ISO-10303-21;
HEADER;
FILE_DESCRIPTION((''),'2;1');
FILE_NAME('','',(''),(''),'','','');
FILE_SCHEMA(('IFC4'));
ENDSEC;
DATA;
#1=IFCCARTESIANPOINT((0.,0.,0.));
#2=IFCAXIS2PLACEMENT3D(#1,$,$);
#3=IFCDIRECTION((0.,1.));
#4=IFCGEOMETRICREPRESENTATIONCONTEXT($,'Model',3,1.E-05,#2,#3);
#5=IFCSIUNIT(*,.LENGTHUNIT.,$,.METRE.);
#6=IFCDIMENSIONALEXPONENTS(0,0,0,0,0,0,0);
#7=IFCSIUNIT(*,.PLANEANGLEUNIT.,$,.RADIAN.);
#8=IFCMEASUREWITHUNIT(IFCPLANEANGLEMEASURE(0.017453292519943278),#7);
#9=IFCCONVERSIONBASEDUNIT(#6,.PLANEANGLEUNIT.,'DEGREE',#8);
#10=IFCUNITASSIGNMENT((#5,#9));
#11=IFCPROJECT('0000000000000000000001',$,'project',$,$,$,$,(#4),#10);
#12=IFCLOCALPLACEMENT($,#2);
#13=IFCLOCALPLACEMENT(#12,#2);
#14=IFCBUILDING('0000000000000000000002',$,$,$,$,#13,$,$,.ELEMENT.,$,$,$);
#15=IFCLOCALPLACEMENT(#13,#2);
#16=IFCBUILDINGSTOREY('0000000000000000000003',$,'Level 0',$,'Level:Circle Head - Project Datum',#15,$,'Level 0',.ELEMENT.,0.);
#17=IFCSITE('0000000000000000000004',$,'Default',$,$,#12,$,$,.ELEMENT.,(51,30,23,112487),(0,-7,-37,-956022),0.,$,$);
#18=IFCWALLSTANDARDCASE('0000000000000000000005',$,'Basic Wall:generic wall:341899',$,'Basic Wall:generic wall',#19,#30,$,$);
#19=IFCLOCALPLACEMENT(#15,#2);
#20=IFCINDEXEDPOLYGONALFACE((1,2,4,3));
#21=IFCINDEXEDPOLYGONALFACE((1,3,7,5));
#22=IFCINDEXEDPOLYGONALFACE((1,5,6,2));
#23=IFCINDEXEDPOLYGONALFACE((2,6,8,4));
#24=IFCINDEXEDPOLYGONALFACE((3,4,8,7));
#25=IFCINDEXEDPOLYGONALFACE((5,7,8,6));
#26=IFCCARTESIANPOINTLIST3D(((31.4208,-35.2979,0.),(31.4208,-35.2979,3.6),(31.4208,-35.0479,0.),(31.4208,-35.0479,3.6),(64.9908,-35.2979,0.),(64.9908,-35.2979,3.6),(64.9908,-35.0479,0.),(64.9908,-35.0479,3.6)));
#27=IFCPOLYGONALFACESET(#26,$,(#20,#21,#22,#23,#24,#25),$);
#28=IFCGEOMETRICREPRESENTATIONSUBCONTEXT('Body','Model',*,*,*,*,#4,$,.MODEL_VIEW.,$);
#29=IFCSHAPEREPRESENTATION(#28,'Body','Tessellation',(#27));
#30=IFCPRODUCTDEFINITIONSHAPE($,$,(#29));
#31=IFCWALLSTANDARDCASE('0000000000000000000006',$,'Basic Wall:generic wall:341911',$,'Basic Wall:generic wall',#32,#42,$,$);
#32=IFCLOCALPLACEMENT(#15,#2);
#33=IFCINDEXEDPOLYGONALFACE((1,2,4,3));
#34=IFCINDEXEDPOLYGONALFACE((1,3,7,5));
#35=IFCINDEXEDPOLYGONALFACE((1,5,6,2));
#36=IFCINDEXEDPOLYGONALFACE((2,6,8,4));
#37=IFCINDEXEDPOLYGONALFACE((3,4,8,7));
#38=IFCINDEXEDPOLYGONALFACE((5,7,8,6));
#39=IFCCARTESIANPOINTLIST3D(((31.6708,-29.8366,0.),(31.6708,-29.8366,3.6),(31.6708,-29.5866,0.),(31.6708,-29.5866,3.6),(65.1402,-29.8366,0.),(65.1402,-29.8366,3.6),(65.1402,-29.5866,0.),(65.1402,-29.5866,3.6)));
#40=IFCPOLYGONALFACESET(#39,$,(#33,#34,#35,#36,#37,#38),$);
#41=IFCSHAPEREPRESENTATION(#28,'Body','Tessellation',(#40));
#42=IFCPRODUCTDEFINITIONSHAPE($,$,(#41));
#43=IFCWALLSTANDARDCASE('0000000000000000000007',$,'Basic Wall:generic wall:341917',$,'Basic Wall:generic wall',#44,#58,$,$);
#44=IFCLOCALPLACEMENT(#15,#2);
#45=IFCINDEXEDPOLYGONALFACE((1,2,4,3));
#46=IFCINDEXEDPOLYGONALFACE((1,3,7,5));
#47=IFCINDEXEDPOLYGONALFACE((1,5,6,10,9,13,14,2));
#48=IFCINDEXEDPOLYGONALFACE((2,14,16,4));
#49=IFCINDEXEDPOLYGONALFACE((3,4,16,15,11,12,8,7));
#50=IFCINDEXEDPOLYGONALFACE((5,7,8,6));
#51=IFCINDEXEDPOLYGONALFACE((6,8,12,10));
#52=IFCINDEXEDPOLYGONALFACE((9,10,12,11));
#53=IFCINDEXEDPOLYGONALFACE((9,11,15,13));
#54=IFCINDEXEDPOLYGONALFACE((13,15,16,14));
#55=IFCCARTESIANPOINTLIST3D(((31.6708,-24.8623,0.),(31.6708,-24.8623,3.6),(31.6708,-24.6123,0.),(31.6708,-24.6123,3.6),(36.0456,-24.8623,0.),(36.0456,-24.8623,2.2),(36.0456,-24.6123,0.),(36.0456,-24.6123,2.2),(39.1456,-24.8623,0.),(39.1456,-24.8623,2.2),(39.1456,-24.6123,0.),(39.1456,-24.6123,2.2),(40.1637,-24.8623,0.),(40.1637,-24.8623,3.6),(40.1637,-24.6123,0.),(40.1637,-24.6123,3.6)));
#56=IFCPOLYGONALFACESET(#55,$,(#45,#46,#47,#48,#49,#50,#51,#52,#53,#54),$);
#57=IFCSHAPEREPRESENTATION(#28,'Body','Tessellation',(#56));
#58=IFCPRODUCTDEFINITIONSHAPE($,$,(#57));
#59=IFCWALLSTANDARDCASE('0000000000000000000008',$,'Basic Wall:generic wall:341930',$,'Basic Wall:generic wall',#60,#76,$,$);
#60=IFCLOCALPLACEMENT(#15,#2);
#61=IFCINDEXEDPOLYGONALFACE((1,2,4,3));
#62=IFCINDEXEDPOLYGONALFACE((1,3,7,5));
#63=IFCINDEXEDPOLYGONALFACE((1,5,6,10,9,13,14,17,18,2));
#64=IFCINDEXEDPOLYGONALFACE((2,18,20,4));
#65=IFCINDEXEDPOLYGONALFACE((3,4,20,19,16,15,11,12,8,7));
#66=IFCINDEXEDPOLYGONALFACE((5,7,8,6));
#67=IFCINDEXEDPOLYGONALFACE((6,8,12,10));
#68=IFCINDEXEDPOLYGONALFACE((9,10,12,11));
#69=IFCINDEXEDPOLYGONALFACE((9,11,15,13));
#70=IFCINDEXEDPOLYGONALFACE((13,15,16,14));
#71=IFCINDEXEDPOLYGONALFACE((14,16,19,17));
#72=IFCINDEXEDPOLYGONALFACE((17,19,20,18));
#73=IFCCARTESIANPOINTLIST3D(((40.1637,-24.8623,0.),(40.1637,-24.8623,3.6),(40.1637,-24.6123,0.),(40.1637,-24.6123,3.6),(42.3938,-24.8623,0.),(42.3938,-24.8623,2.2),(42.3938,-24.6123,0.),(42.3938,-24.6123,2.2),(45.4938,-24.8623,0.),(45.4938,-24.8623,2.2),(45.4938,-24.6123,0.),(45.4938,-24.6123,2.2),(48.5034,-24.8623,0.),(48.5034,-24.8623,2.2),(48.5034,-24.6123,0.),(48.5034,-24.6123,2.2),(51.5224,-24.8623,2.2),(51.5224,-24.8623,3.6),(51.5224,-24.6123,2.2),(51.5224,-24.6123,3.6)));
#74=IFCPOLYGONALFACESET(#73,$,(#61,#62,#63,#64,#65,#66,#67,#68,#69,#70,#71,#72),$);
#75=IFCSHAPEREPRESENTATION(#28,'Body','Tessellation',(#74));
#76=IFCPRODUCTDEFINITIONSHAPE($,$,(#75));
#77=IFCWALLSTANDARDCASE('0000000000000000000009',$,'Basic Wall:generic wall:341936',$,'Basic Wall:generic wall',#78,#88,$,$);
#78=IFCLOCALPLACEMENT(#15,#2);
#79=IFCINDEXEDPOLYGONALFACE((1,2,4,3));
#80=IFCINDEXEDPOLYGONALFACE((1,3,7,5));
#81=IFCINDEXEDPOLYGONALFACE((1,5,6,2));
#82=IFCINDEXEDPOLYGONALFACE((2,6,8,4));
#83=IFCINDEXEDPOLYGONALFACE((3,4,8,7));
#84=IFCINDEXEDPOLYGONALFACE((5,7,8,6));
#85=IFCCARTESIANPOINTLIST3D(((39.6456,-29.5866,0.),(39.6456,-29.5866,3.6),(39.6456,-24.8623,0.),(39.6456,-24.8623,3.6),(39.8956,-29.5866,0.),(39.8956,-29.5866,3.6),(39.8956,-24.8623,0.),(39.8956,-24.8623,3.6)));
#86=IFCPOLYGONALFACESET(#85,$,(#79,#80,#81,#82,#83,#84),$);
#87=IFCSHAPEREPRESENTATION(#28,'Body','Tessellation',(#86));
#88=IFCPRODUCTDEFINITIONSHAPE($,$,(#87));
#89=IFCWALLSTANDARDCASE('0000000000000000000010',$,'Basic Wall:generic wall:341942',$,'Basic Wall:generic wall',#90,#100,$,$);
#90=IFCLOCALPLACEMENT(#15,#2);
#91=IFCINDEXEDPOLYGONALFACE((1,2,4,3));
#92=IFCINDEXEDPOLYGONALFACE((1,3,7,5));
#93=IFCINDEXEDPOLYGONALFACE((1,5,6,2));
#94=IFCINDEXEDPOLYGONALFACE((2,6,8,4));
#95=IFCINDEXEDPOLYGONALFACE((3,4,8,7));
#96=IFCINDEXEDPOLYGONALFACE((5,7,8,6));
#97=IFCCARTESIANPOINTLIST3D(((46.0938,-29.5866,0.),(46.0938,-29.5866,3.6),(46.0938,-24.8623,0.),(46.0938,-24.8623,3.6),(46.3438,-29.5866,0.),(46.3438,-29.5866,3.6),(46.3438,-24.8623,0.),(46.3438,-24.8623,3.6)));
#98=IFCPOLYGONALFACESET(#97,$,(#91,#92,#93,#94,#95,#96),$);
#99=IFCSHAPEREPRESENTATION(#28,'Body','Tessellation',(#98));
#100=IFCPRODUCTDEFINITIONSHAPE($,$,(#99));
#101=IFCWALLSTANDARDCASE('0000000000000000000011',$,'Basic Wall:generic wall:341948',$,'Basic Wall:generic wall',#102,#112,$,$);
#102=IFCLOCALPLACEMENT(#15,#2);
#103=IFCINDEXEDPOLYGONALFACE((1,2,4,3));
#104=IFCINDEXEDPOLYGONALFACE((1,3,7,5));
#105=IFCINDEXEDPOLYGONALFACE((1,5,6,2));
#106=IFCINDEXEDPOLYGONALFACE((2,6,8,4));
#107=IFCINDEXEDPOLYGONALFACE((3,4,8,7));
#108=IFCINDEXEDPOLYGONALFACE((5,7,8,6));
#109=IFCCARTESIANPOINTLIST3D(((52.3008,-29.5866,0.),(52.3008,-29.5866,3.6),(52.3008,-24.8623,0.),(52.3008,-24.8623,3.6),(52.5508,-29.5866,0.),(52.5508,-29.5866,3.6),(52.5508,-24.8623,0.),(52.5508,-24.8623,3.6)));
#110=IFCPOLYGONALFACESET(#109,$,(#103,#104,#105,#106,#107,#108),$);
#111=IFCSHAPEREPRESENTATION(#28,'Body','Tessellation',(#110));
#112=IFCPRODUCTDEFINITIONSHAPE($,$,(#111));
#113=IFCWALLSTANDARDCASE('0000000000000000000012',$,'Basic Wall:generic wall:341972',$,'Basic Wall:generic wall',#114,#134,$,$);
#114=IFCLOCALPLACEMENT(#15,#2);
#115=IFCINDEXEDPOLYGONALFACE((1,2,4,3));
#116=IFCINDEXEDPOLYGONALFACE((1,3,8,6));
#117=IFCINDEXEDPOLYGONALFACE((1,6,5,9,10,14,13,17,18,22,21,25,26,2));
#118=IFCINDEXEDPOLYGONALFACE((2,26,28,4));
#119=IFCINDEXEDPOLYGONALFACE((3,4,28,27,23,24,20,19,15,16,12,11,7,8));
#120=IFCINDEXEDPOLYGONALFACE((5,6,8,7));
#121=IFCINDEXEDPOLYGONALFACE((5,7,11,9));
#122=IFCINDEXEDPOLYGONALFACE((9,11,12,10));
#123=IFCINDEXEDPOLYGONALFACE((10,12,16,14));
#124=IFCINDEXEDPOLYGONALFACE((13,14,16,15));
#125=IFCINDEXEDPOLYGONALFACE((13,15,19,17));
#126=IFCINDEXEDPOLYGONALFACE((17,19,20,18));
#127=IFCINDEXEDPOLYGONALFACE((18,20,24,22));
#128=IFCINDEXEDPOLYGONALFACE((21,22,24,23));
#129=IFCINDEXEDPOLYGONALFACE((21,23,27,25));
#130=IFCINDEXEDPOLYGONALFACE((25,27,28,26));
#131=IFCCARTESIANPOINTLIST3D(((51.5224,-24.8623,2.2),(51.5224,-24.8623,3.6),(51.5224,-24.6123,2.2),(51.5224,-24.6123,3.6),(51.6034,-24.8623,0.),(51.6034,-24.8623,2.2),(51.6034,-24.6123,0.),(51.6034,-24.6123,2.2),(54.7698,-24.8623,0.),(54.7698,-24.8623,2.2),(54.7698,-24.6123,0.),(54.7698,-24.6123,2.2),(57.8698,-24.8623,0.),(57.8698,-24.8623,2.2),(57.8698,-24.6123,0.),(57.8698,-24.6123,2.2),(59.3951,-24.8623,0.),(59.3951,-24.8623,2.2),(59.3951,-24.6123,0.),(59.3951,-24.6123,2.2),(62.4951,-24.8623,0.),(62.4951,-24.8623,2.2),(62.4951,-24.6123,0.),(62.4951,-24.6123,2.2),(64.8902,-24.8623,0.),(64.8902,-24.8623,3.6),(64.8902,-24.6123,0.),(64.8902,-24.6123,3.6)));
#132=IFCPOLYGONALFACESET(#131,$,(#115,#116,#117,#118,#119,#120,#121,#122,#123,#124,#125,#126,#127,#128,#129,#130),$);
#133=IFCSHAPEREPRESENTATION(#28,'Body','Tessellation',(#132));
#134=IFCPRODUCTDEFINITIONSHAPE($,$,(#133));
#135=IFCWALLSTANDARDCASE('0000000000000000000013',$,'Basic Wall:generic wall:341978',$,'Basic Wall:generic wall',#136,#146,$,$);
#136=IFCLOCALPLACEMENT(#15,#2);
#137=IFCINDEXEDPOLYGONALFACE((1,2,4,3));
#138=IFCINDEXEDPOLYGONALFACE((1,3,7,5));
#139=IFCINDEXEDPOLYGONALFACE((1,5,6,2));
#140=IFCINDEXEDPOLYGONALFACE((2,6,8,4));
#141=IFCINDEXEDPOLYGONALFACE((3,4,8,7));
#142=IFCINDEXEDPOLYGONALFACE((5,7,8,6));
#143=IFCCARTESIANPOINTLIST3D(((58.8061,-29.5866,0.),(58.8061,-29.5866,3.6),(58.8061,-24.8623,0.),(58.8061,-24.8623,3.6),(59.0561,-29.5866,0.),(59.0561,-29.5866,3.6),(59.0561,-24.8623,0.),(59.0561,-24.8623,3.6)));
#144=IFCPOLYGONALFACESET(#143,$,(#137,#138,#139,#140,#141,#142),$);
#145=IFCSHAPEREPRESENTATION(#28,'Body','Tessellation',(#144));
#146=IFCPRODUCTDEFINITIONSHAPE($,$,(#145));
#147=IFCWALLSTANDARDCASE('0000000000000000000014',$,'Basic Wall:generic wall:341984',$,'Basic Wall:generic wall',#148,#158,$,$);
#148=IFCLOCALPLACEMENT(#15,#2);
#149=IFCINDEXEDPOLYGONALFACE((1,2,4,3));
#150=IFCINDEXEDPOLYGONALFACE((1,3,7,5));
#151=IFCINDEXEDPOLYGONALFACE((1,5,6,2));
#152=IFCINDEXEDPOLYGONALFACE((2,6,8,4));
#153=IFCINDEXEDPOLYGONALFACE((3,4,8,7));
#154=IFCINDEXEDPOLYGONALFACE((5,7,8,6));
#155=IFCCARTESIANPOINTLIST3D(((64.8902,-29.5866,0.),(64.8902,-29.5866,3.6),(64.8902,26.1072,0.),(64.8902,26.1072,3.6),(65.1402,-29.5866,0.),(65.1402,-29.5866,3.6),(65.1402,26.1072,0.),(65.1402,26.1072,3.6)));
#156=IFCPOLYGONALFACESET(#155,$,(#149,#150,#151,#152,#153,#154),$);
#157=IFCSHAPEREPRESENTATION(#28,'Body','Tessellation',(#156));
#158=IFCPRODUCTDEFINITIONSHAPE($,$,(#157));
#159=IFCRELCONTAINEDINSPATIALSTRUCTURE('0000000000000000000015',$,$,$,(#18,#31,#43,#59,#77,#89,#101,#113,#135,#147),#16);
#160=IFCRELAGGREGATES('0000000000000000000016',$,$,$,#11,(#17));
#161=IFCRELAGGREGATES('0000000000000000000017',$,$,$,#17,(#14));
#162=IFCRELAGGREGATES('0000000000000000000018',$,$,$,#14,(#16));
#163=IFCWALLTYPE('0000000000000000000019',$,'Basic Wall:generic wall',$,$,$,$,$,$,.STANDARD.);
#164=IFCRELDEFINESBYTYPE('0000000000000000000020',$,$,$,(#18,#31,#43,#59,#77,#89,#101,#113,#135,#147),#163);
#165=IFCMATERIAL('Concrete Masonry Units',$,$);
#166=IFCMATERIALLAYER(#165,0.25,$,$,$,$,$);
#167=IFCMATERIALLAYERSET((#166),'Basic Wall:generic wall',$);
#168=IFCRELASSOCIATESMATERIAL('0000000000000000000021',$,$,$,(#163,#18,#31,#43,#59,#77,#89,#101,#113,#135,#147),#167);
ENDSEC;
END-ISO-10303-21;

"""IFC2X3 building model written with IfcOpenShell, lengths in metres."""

from ifc_helpers import new_model, entity, si_unit, converted_unit, direction, frame, frame_2d, origin, place, context, subcontext, project, spatial, rectangle, extrude, material, layer, layer_set, layer_usage, type_object, element, save


model = new_model("IFC2X3")

# Units and contexts
model_context = context("Model", 3, precision=1e-05, world=origin(), true_north=direction((0.0, 1.0)))
body_context = subcontext(model_context, "Body", "Model", "MODEL_VIEW")
ifc_project = project(units=[si_unit("LENGTHUNIT", "METRE"), converted_unit("PLANEANGLEUNIT", "DEGREE", entity("IfcPlaneAngleMeasure", 0.017453292519943278), si_unit("PLANEANGLEUNIT", "RADIAN"), dimensions=[0, 0, 0, 0, 0, 0, 0])], contexts=[model_context])

# Site, building, storey
site_placement = place(None, origin())
site = spatial("IfcSite", under=ifc_project, at=site_placement, Name="Default", CompositionType="ELEMENT", RefLatitude=(51, 30, 23, 112487), RefLongitude=(0, -7, -37, -956022), RefElevation=0.0)
building_placement = place(site_placement, origin())
building = spatial("IfcBuilding", under=site, at=building_placement, CompositionType="ELEMENT")
storey_placement = place(building_placement, origin())
storey = spatial("IfcBuildingStorey", under=building, at=storey_placement, Name="Level 0", ObjectType="Level:Circle Head - Project Datum", LongName="Level 0", CompositionType="ELEMENT", Elevation=0.0)

# Shared definitions
ifc_material = material(Name="Concrete Masonry Units")
ifc_layer = layer(ifc_material, 0.25)
ifc_layer_set = layer_set([ifc_layer], Name="Basic Wall:generic wall")
wall_type = type_object("IfcWallType", Name="Basic Wall:generic wall", PredefinedType="STANDARD", material=ifc_layer_set)

# Walls
ifc_layer_usage_1 = layer_usage(ifc_layer_set, "AXIS2", "NEGATIVE", 0.125)
wall_1_placement = place(storey_placement, frame((64.9908, -35.1729, 0.0), z_axis=(0.0, 0.0, 1.0), x_axis=(-1.0, 0.0, 0.0)))
element("IfcWallStandardCase", 1, at=wall_1_placement, inside=storey, type_object=wall_type, material=ifc_layer_usage_1, Name="Basic Wall:generic wall:341899", ObjectType="Basic Wall:generic wall", context=body_context, shape_type="SweptSolid", body=[
    extrude(rectangle(XDim=33.57, YDim=0.25, at=frame_2d((16.785, 0.0), x_axis=(-1.0, 0.0))), origin(), (0.0, 0.0, 1.0), 3.6),
])
ifc_layer_usage_2 = layer_usage(ifc_layer_set, "AXIS2", "NEGATIVE", 0.125)
wall_2_placement = place(storey_placement, frame((31.6708, -29.7116, 0.0)))
element("IfcWallStandardCase", 2, at=wall_2_placement, inside=storey, type_object=wall_type, material=ifc_layer_usage_2, Name="Basic Wall:generic wall:341911", ObjectType="Basic Wall:generic wall", context=body_context, shape_type="SweptSolid", body=[
    extrude(rectangle(XDim=33.4694, YDim=0.25, at=frame_2d((16.7347, 0.0), x_axis=(-1.0, 0.0))), origin(), (0.0, 0.0, 1.0), 3.6),
])

# Wall, opening
ifc_layer_usage_3 = layer_usage(ifc_layer_set, "AXIS2", "NEGATIVE", 0.125)
wall_3_placement = place(storey_placement, frame((31.6708, -24.7373, 0.0)))
wall_3 = element("IfcWallStandardCase", 3, at=wall_3_placement, inside=storey, type_object=wall_type, material=ifc_layer_usage_3, Name="Basic Wall:generic wall:341917", ObjectType="Basic Wall:generic wall", context=body_context, shape_type="SweptSolid", body=[
    extrude(rectangle(XDim=8.4929, YDim=0.25, at=frame_2d((4.2465, 0.0), x_axis=(-1.0, 0.0))), origin(), (0.0, 0.0, 1.0), 3.6),
])
opening_1_placement = place(wall_3_placement, frame((7.4748, 0.125, 0.0)))
element("IfcOpeningElement", 4, at=opening_1_placement, cuts=wall_3, ObjectType="Opening", context=body_context, shape_type="SweptSolid", body=[
    extrude(rectangle(XDim=2.2, YDim=3.1, at=frame_2d((1.1, 1.55), x_axis=(1.0, 0.0))), frame((0.0, 0.0, 0.0), z_axis=(0.0, -1.0, 0.0), x_axis=(0.0, 0.0, 1.0)), (0.0, 0.0, 1.0), 0.25),
])

# Wall, openings
ifc_layer_usage_4 = layer_usage(ifc_layer_set, "AXIS2", "NEGATIVE", 0.125)
wall_4_placement = place(storey_placement, frame((40.1637, -24.7373, 0.0)))
wall_4 = element("IfcWallStandardCase", 5, at=wall_4_placement, inside=storey, type_object=wall_type, material=ifc_layer_usage_4, Name="Basic Wall:generic wall:341930", ObjectType="Basic Wall:generic wall", context=body_context, shape_type="SweptSolid", body=[
    extrude(rectangle(XDim=11.3587, YDim=0.25, at=frame_2d((5.6794, 0.0), x_axis=(-1.0, 0.0))), origin(), (0.0, 0.0, 1.0), 3.6),
])
opening_2_placement = place(wall_4_placement, frame((11.4397, 0.125, 0.0)))
element("IfcOpeningElement", 6, at=opening_2_placement, cuts=wall_4, ObjectType="Opening", context=body_context, shape_type="SweptSolid", body=[
    extrude(rectangle(XDim=2.2, YDim=3.1, at=frame_2d((1.1, 1.55), x_axis=(1.0, 0.0))), frame((0.0, 0.0, 0.0), z_axis=(0.0, -1.0, 0.0), x_axis=(0.0, 0.0, 1.0)), (0.0, 0.0, 1.0), 0.25),
])
opening_3_placement = place(wall_4_placement, frame((5.3301, 0.125, 0.0)))
element("IfcOpeningElement", 7, at=opening_3_placement, cuts=wall_4, ObjectType="Opening", context=body_context, shape_type="SweptSolid", body=[
    extrude(rectangle(XDim=2.2, YDim=3.1, at=frame_2d((1.1, 1.55), x_axis=(1.0, 0.0))), frame((0.0, 0.0, 0.0), z_axis=(0.0, -1.0, 0.0), x_axis=(0.0, 0.0, 1.0)), (0.0, 0.0, 1.0), 0.25),
])

# Walls
ifc_layer_usage_5 = layer_usage(ifc_layer_set, "AXIS2", "NEGATIVE", 0.125)
wall_5_placement = place(storey_placement, frame((39.7706, -24.8623, 0.0), z_axis=(0.0, 0.0, 1.0), x_axis=(0.0, -1.0, 0.0)))
element("IfcWallStandardCase", 8, at=wall_5_placement, inside=storey, type_object=wall_type, material=ifc_layer_usage_5, Name="Basic Wall:generic wall:341936", ObjectType="Basic Wall:generic wall", context=body_context, shape_type="SweptSolid", body=[
    extrude(rectangle(XDim=4.7244, YDim=0.25, at=frame_2d((2.3622, 0.0), x_axis=(-1.0, 0.0))), origin(), (0.0, 0.0, 1.0), 3.6),
])
ifc_layer_usage_6 = layer_usage(ifc_layer_set, "AXIS2", "NEGATIVE", 0.125)
wall_6_placement = place(storey_placement, frame((46.2188, -24.8623, 0.0), z_axis=(0.0, 0.0, 1.0), x_axis=(0.0, -1.0, 0.0)))
element("IfcWallStandardCase", 9, at=wall_6_placement, inside=storey, type_object=wall_type, material=ifc_layer_usage_6, Name="Basic Wall:generic wall:341942", ObjectType="Basic Wall:generic wall", context=body_context, shape_type="SweptSolid", body=[
    extrude(rectangle(XDim=4.7244, YDim=0.25, at=frame_2d((2.3622, 0.0), x_axis=(-1.0, 0.0))), origin(), (0.0, 0.0, 1.0), 3.6),
])
ifc_layer_usage_7 = layer_usage(ifc_layer_set, "AXIS2", "NEGATIVE", 0.125)
wall_7_placement = place(storey_placement, frame((52.4258, -29.5866, 0.0), z_axis=(0.0, 0.0, 1.0), x_axis=(0.0, 1.0, 0.0)))
element("IfcWallStandardCase", 10, at=wall_7_placement, inside=storey, type_object=wall_type, material=ifc_layer_usage_7, Name="Basic Wall:generic wall:341948", ObjectType="Basic Wall:generic wall", context=body_context, shape_type="SweptSolid", body=[
    extrude(rectangle(XDim=4.7244, YDim=0.25, at=frame_2d((2.3622, 0.0), x_axis=(-1.0, 0.0))), origin(), (0.0, 0.0, 1.0), 3.6),
])

# Wall, openings
ifc_layer_usage_8 = layer_usage(ifc_layer_set, "AXIS2", "NEGATIVE", 0.125)
wall_8_placement = place(storey_placement, frame((51.5224, -24.7373, 0.0)))
wall_8 = element("IfcWallStandardCase", 11, at=wall_8_placement, inside=storey, type_object=wall_type, material=ifc_layer_usage_8, Name="Basic Wall:generic wall:341972", ObjectType="Basic Wall:generic wall", context=body_context, shape_type="SweptSolid", body=[
    extrude(rectangle(XDim=13.3677, YDim=0.25, at=frame_2d((6.6839, 0.0), x_axis=(-1.0, 0.0))), origin(), (0.0, 0.0, 1.0), 3.6),
])
opening_4_placement = place(wall_8_placement, origin())
element("IfcOpeningElement", 12, at=opening_4_placement, cuts=wall_8, ObjectType="Opening", context=body_context, shape_type="SweptSolid", body=[
    extrude(rectangle(XDim=2.2, YDim=3.1, at=frame_2d((0.0, 0.0), x_axis=(1.0, 0.0))), frame((-1.469, -1.399, 1.1), z_axis=(0.0, 1.0, 0.0), x_axis=(0.0, 0.0, 1.0)), (0.0, 0.0, 1.0), 3.048),
])
opening_5_placement = place(wall_8_placement, frame((10.9727, 0.125, 0.0)))
element("IfcOpeningElement", 13, at=opening_5_placement, cuts=wall_8, ObjectType="Opening", context=body_context, shape_type="SweptSolid", body=[
    extrude(rectangle(XDim=2.2, YDim=3.1, at=frame_2d((1.1, 1.55), x_axis=(1.0, 0.0))), frame((0.0, 0.0, 0.0), z_axis=(0.0, -1.0, 0.0), x_axis=(0.0, 0.0, 1.0)), (0.0, 0.0, 1.0), 0.25),
])
opening_6_placement = place(wall_8_placement, frame((6.3474, 0.125, 0.0)))
element("IfcOpeningElement", 14, at=opening_6_placement, cuts=wall_8, ObjectType="Opening", context=body_context, shape_type="SweptSolid", body=[
    extrude(rectangle(XDim=2.2, YDim=3.1, at=frame_2d((1.1, 1.55), x_axis=(1.0, 0.0))), frame((0.0, 0.0, 0.0), z_axis=(0.0, -1.0, 0.0), x_axis=(0.0, 0.0, 1.0)), (0.0, 0.0, 1.0), 0.25),
])

# Walls
ifc_layer_usage_9 = layer_usage(ifc_layer_set, "AXIS2", "NEGATIVE", 0.125)
wall_9_placement = place(storey_placement, frame((58.9311, -24.8623, 0.0), z_axis=(0.0, 0.0, 1.0), x_axis=(0.0, -1.0, 0.0)))
element("IfcWallStandardCase", 15, at=wall_9_placement, inside=storey, type_object=wall_type, material=ifc_layer_usage_9, Name="Basic Wall:generic wall:341978", ObjectType="Basic Wall:generic wall", context=body_context, shape_type="SweptSolid", body=[
    extrude(rectangle(XDim=4.7244, YDim=0.25, at=frame_2d((2.3622, 0.0), x_axis=(-1.0, 0.0))), origin(), (0.0, 0.0, 1.0), 3.6),
])
ifc_layer_usage_10 = layer_usage(ifc_layer_set, "AXIS2", "NEGATIVE", 0.125)
wall_10_placement = place(storey_placement, frame((65.0152, -29.5866, 0.0), z_axis=(0.0, 0.0, 1.0), x_axis=(0.0, 1.0, 0.0)))
element("IfcWallStandardCase", 16, at=wall_10_placement, inside=storey, type_object=wall_type, material=ifc_layer_usage_10, Name="Basic Wall:generic wall:341984", ObjectType="Basic Wall:generic wall", context=body_context, shape_type="SweptSolid", body=[
    extrude(rectangle(XDim=55.6939, YDim=0.25, at=frame_2d((27.8469, 0.0), x_axis=(-1.0, 0.0))), origin(), (0.0, 0.0, 1.0), 3.6),
])

save(model, "model.ifc")
